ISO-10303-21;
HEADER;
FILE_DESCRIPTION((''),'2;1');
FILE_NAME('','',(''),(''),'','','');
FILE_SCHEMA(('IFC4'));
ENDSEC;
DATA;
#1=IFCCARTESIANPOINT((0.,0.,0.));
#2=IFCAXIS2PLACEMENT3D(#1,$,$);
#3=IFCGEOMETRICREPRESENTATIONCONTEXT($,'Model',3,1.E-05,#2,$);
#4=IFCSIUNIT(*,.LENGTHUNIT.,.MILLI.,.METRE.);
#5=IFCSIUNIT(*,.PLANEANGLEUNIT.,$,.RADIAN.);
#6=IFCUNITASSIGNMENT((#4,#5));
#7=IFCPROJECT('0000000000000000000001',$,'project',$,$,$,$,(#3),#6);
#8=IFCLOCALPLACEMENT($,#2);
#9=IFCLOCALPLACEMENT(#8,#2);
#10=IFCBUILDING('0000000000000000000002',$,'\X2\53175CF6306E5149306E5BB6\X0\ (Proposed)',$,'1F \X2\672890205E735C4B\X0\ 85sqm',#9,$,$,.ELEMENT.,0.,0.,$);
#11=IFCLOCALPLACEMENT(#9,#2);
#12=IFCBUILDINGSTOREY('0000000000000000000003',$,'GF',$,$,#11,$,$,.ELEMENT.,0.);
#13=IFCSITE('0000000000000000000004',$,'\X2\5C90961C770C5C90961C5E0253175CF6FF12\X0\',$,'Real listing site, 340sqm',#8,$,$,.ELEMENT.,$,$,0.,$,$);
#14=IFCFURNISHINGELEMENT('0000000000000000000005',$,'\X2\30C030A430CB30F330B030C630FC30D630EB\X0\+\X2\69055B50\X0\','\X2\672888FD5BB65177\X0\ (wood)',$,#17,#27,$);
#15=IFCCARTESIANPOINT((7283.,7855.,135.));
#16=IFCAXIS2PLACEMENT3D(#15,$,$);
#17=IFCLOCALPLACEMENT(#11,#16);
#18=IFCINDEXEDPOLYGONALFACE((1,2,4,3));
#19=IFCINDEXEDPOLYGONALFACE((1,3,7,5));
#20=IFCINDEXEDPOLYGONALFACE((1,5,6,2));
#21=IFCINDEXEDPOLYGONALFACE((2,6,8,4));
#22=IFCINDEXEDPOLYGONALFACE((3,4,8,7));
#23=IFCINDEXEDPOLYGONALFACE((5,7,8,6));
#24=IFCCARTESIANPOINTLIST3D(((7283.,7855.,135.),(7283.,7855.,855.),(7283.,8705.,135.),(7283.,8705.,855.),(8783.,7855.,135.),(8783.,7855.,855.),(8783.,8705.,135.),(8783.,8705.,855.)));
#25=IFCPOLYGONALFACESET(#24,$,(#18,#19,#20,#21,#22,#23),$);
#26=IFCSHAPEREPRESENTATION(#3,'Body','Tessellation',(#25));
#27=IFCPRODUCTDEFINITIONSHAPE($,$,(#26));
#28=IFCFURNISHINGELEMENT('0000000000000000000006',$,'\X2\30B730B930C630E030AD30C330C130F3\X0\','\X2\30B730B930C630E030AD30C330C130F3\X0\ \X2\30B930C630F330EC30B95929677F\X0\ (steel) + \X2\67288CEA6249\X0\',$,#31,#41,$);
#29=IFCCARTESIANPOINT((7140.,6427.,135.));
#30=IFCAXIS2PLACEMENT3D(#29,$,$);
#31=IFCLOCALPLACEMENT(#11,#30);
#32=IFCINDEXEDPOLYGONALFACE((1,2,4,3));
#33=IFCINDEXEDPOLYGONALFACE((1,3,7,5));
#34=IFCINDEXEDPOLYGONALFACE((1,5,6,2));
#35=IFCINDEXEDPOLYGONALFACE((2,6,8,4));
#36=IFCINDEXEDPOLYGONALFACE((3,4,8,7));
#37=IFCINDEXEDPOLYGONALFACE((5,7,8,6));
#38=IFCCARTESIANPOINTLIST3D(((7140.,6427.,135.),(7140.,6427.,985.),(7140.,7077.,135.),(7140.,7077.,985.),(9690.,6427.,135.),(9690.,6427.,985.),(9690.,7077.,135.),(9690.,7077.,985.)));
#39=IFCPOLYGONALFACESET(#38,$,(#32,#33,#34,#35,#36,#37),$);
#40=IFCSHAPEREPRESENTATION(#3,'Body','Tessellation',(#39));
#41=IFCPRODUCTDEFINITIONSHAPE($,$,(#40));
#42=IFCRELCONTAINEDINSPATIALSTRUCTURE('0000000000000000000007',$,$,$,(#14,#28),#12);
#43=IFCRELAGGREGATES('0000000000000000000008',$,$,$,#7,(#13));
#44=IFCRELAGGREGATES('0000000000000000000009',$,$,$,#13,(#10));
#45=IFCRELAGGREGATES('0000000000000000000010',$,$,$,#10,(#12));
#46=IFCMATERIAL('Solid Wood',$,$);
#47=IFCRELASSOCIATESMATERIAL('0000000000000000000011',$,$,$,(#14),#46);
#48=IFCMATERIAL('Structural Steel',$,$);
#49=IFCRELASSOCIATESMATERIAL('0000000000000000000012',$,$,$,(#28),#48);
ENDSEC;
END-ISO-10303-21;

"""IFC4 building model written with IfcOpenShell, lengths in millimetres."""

from ifc_helpers import new_model, si_unit, frame, frame_2d, origin, place, context, project, spatial, rectangle, extrude, material, element, save


model = new_model("IFC4")

# Units and contexts
model_context = context("Model", 3, precision=1e-05, world=origin())
ifc_project = project(units=[si_unit("LENGTHUNIT", "METRE", prefix="MILLI"), si_unit("PLANEANGLEUNIT", "RADIAN")], contexts=[model_context])

# Site, building, storey
site_placement = place(None, origin())
site = spatial("IfcSite", under=ifc_project, at=site_placement, Name="岐阜県岐阜市北島２", ObjectType="Real listing site, 340sqm", CompositionType="ELEMENT", RefElevation=0.0)
building_placement = place(site_placement, origin())
building = spatial("IfcBuilding", under=site, at=building_placement, Name="北島の光の家 (Proposed)", ObjectType="1F 木造平屋 85sqm", CompositionType="ELEMENT", ElevationOfRefHeight=0.0, ElevationOfTerrain=0.0)
storey_placement = place(building_placement, origin())
storey = spatial("IfcBuildingStorey", under=building, at=storey_placement, Name="GF", CompositionType="ELEMENT", Elevation=0.0)

# Shared definitions
ifc_material_1 = material(Name="Solid Wood")

# Shared definitions
ifc_material_2 = material(Name="Structural Steel")

# Furnishing elements
furnishing_1_placement = place(storey_placement, frame((7283.0, 7855.0, 135.0)))
element("IfcFurnishingElement", 1, at=furnishing_1_placement, inside=storey, material=ifc_material_1, Name="ダイニングテーブル+椅子", Description="木製家具 (wood)", context=model_context, shape_type="SweptSolid", body=[
    extrude(rectangle(XDim=1500.0, YDim=850.0, at=frame_2d((750.0, 425.0))), frame((7283.0, 7855.0, 135.0)), (0.0, 0.0, 1.0), 720.0),
])
furnishing_2_placement = place(storey_placement, frame((7140.0, 6427.0, 135.0)))
element("IfcFurnishingElement", 2, at=furnishing_2_placement, inside=storey, material=ifc_material_2, Name="システムキッチン", Description="システムキッチン ステンレス天板 (steel) + 木質扉", context=model_context, shape_type="SweptSolid", body=[
    extrude(rectangle(XDim=2550.0, YDim=650.0, at=frame_2d((1275.0, 325.0))), frame((7140.0, 6427.0, 135.0)), (0.0, 0.0, 1.0), 850.0),
])

save(model, "model.ifc")
